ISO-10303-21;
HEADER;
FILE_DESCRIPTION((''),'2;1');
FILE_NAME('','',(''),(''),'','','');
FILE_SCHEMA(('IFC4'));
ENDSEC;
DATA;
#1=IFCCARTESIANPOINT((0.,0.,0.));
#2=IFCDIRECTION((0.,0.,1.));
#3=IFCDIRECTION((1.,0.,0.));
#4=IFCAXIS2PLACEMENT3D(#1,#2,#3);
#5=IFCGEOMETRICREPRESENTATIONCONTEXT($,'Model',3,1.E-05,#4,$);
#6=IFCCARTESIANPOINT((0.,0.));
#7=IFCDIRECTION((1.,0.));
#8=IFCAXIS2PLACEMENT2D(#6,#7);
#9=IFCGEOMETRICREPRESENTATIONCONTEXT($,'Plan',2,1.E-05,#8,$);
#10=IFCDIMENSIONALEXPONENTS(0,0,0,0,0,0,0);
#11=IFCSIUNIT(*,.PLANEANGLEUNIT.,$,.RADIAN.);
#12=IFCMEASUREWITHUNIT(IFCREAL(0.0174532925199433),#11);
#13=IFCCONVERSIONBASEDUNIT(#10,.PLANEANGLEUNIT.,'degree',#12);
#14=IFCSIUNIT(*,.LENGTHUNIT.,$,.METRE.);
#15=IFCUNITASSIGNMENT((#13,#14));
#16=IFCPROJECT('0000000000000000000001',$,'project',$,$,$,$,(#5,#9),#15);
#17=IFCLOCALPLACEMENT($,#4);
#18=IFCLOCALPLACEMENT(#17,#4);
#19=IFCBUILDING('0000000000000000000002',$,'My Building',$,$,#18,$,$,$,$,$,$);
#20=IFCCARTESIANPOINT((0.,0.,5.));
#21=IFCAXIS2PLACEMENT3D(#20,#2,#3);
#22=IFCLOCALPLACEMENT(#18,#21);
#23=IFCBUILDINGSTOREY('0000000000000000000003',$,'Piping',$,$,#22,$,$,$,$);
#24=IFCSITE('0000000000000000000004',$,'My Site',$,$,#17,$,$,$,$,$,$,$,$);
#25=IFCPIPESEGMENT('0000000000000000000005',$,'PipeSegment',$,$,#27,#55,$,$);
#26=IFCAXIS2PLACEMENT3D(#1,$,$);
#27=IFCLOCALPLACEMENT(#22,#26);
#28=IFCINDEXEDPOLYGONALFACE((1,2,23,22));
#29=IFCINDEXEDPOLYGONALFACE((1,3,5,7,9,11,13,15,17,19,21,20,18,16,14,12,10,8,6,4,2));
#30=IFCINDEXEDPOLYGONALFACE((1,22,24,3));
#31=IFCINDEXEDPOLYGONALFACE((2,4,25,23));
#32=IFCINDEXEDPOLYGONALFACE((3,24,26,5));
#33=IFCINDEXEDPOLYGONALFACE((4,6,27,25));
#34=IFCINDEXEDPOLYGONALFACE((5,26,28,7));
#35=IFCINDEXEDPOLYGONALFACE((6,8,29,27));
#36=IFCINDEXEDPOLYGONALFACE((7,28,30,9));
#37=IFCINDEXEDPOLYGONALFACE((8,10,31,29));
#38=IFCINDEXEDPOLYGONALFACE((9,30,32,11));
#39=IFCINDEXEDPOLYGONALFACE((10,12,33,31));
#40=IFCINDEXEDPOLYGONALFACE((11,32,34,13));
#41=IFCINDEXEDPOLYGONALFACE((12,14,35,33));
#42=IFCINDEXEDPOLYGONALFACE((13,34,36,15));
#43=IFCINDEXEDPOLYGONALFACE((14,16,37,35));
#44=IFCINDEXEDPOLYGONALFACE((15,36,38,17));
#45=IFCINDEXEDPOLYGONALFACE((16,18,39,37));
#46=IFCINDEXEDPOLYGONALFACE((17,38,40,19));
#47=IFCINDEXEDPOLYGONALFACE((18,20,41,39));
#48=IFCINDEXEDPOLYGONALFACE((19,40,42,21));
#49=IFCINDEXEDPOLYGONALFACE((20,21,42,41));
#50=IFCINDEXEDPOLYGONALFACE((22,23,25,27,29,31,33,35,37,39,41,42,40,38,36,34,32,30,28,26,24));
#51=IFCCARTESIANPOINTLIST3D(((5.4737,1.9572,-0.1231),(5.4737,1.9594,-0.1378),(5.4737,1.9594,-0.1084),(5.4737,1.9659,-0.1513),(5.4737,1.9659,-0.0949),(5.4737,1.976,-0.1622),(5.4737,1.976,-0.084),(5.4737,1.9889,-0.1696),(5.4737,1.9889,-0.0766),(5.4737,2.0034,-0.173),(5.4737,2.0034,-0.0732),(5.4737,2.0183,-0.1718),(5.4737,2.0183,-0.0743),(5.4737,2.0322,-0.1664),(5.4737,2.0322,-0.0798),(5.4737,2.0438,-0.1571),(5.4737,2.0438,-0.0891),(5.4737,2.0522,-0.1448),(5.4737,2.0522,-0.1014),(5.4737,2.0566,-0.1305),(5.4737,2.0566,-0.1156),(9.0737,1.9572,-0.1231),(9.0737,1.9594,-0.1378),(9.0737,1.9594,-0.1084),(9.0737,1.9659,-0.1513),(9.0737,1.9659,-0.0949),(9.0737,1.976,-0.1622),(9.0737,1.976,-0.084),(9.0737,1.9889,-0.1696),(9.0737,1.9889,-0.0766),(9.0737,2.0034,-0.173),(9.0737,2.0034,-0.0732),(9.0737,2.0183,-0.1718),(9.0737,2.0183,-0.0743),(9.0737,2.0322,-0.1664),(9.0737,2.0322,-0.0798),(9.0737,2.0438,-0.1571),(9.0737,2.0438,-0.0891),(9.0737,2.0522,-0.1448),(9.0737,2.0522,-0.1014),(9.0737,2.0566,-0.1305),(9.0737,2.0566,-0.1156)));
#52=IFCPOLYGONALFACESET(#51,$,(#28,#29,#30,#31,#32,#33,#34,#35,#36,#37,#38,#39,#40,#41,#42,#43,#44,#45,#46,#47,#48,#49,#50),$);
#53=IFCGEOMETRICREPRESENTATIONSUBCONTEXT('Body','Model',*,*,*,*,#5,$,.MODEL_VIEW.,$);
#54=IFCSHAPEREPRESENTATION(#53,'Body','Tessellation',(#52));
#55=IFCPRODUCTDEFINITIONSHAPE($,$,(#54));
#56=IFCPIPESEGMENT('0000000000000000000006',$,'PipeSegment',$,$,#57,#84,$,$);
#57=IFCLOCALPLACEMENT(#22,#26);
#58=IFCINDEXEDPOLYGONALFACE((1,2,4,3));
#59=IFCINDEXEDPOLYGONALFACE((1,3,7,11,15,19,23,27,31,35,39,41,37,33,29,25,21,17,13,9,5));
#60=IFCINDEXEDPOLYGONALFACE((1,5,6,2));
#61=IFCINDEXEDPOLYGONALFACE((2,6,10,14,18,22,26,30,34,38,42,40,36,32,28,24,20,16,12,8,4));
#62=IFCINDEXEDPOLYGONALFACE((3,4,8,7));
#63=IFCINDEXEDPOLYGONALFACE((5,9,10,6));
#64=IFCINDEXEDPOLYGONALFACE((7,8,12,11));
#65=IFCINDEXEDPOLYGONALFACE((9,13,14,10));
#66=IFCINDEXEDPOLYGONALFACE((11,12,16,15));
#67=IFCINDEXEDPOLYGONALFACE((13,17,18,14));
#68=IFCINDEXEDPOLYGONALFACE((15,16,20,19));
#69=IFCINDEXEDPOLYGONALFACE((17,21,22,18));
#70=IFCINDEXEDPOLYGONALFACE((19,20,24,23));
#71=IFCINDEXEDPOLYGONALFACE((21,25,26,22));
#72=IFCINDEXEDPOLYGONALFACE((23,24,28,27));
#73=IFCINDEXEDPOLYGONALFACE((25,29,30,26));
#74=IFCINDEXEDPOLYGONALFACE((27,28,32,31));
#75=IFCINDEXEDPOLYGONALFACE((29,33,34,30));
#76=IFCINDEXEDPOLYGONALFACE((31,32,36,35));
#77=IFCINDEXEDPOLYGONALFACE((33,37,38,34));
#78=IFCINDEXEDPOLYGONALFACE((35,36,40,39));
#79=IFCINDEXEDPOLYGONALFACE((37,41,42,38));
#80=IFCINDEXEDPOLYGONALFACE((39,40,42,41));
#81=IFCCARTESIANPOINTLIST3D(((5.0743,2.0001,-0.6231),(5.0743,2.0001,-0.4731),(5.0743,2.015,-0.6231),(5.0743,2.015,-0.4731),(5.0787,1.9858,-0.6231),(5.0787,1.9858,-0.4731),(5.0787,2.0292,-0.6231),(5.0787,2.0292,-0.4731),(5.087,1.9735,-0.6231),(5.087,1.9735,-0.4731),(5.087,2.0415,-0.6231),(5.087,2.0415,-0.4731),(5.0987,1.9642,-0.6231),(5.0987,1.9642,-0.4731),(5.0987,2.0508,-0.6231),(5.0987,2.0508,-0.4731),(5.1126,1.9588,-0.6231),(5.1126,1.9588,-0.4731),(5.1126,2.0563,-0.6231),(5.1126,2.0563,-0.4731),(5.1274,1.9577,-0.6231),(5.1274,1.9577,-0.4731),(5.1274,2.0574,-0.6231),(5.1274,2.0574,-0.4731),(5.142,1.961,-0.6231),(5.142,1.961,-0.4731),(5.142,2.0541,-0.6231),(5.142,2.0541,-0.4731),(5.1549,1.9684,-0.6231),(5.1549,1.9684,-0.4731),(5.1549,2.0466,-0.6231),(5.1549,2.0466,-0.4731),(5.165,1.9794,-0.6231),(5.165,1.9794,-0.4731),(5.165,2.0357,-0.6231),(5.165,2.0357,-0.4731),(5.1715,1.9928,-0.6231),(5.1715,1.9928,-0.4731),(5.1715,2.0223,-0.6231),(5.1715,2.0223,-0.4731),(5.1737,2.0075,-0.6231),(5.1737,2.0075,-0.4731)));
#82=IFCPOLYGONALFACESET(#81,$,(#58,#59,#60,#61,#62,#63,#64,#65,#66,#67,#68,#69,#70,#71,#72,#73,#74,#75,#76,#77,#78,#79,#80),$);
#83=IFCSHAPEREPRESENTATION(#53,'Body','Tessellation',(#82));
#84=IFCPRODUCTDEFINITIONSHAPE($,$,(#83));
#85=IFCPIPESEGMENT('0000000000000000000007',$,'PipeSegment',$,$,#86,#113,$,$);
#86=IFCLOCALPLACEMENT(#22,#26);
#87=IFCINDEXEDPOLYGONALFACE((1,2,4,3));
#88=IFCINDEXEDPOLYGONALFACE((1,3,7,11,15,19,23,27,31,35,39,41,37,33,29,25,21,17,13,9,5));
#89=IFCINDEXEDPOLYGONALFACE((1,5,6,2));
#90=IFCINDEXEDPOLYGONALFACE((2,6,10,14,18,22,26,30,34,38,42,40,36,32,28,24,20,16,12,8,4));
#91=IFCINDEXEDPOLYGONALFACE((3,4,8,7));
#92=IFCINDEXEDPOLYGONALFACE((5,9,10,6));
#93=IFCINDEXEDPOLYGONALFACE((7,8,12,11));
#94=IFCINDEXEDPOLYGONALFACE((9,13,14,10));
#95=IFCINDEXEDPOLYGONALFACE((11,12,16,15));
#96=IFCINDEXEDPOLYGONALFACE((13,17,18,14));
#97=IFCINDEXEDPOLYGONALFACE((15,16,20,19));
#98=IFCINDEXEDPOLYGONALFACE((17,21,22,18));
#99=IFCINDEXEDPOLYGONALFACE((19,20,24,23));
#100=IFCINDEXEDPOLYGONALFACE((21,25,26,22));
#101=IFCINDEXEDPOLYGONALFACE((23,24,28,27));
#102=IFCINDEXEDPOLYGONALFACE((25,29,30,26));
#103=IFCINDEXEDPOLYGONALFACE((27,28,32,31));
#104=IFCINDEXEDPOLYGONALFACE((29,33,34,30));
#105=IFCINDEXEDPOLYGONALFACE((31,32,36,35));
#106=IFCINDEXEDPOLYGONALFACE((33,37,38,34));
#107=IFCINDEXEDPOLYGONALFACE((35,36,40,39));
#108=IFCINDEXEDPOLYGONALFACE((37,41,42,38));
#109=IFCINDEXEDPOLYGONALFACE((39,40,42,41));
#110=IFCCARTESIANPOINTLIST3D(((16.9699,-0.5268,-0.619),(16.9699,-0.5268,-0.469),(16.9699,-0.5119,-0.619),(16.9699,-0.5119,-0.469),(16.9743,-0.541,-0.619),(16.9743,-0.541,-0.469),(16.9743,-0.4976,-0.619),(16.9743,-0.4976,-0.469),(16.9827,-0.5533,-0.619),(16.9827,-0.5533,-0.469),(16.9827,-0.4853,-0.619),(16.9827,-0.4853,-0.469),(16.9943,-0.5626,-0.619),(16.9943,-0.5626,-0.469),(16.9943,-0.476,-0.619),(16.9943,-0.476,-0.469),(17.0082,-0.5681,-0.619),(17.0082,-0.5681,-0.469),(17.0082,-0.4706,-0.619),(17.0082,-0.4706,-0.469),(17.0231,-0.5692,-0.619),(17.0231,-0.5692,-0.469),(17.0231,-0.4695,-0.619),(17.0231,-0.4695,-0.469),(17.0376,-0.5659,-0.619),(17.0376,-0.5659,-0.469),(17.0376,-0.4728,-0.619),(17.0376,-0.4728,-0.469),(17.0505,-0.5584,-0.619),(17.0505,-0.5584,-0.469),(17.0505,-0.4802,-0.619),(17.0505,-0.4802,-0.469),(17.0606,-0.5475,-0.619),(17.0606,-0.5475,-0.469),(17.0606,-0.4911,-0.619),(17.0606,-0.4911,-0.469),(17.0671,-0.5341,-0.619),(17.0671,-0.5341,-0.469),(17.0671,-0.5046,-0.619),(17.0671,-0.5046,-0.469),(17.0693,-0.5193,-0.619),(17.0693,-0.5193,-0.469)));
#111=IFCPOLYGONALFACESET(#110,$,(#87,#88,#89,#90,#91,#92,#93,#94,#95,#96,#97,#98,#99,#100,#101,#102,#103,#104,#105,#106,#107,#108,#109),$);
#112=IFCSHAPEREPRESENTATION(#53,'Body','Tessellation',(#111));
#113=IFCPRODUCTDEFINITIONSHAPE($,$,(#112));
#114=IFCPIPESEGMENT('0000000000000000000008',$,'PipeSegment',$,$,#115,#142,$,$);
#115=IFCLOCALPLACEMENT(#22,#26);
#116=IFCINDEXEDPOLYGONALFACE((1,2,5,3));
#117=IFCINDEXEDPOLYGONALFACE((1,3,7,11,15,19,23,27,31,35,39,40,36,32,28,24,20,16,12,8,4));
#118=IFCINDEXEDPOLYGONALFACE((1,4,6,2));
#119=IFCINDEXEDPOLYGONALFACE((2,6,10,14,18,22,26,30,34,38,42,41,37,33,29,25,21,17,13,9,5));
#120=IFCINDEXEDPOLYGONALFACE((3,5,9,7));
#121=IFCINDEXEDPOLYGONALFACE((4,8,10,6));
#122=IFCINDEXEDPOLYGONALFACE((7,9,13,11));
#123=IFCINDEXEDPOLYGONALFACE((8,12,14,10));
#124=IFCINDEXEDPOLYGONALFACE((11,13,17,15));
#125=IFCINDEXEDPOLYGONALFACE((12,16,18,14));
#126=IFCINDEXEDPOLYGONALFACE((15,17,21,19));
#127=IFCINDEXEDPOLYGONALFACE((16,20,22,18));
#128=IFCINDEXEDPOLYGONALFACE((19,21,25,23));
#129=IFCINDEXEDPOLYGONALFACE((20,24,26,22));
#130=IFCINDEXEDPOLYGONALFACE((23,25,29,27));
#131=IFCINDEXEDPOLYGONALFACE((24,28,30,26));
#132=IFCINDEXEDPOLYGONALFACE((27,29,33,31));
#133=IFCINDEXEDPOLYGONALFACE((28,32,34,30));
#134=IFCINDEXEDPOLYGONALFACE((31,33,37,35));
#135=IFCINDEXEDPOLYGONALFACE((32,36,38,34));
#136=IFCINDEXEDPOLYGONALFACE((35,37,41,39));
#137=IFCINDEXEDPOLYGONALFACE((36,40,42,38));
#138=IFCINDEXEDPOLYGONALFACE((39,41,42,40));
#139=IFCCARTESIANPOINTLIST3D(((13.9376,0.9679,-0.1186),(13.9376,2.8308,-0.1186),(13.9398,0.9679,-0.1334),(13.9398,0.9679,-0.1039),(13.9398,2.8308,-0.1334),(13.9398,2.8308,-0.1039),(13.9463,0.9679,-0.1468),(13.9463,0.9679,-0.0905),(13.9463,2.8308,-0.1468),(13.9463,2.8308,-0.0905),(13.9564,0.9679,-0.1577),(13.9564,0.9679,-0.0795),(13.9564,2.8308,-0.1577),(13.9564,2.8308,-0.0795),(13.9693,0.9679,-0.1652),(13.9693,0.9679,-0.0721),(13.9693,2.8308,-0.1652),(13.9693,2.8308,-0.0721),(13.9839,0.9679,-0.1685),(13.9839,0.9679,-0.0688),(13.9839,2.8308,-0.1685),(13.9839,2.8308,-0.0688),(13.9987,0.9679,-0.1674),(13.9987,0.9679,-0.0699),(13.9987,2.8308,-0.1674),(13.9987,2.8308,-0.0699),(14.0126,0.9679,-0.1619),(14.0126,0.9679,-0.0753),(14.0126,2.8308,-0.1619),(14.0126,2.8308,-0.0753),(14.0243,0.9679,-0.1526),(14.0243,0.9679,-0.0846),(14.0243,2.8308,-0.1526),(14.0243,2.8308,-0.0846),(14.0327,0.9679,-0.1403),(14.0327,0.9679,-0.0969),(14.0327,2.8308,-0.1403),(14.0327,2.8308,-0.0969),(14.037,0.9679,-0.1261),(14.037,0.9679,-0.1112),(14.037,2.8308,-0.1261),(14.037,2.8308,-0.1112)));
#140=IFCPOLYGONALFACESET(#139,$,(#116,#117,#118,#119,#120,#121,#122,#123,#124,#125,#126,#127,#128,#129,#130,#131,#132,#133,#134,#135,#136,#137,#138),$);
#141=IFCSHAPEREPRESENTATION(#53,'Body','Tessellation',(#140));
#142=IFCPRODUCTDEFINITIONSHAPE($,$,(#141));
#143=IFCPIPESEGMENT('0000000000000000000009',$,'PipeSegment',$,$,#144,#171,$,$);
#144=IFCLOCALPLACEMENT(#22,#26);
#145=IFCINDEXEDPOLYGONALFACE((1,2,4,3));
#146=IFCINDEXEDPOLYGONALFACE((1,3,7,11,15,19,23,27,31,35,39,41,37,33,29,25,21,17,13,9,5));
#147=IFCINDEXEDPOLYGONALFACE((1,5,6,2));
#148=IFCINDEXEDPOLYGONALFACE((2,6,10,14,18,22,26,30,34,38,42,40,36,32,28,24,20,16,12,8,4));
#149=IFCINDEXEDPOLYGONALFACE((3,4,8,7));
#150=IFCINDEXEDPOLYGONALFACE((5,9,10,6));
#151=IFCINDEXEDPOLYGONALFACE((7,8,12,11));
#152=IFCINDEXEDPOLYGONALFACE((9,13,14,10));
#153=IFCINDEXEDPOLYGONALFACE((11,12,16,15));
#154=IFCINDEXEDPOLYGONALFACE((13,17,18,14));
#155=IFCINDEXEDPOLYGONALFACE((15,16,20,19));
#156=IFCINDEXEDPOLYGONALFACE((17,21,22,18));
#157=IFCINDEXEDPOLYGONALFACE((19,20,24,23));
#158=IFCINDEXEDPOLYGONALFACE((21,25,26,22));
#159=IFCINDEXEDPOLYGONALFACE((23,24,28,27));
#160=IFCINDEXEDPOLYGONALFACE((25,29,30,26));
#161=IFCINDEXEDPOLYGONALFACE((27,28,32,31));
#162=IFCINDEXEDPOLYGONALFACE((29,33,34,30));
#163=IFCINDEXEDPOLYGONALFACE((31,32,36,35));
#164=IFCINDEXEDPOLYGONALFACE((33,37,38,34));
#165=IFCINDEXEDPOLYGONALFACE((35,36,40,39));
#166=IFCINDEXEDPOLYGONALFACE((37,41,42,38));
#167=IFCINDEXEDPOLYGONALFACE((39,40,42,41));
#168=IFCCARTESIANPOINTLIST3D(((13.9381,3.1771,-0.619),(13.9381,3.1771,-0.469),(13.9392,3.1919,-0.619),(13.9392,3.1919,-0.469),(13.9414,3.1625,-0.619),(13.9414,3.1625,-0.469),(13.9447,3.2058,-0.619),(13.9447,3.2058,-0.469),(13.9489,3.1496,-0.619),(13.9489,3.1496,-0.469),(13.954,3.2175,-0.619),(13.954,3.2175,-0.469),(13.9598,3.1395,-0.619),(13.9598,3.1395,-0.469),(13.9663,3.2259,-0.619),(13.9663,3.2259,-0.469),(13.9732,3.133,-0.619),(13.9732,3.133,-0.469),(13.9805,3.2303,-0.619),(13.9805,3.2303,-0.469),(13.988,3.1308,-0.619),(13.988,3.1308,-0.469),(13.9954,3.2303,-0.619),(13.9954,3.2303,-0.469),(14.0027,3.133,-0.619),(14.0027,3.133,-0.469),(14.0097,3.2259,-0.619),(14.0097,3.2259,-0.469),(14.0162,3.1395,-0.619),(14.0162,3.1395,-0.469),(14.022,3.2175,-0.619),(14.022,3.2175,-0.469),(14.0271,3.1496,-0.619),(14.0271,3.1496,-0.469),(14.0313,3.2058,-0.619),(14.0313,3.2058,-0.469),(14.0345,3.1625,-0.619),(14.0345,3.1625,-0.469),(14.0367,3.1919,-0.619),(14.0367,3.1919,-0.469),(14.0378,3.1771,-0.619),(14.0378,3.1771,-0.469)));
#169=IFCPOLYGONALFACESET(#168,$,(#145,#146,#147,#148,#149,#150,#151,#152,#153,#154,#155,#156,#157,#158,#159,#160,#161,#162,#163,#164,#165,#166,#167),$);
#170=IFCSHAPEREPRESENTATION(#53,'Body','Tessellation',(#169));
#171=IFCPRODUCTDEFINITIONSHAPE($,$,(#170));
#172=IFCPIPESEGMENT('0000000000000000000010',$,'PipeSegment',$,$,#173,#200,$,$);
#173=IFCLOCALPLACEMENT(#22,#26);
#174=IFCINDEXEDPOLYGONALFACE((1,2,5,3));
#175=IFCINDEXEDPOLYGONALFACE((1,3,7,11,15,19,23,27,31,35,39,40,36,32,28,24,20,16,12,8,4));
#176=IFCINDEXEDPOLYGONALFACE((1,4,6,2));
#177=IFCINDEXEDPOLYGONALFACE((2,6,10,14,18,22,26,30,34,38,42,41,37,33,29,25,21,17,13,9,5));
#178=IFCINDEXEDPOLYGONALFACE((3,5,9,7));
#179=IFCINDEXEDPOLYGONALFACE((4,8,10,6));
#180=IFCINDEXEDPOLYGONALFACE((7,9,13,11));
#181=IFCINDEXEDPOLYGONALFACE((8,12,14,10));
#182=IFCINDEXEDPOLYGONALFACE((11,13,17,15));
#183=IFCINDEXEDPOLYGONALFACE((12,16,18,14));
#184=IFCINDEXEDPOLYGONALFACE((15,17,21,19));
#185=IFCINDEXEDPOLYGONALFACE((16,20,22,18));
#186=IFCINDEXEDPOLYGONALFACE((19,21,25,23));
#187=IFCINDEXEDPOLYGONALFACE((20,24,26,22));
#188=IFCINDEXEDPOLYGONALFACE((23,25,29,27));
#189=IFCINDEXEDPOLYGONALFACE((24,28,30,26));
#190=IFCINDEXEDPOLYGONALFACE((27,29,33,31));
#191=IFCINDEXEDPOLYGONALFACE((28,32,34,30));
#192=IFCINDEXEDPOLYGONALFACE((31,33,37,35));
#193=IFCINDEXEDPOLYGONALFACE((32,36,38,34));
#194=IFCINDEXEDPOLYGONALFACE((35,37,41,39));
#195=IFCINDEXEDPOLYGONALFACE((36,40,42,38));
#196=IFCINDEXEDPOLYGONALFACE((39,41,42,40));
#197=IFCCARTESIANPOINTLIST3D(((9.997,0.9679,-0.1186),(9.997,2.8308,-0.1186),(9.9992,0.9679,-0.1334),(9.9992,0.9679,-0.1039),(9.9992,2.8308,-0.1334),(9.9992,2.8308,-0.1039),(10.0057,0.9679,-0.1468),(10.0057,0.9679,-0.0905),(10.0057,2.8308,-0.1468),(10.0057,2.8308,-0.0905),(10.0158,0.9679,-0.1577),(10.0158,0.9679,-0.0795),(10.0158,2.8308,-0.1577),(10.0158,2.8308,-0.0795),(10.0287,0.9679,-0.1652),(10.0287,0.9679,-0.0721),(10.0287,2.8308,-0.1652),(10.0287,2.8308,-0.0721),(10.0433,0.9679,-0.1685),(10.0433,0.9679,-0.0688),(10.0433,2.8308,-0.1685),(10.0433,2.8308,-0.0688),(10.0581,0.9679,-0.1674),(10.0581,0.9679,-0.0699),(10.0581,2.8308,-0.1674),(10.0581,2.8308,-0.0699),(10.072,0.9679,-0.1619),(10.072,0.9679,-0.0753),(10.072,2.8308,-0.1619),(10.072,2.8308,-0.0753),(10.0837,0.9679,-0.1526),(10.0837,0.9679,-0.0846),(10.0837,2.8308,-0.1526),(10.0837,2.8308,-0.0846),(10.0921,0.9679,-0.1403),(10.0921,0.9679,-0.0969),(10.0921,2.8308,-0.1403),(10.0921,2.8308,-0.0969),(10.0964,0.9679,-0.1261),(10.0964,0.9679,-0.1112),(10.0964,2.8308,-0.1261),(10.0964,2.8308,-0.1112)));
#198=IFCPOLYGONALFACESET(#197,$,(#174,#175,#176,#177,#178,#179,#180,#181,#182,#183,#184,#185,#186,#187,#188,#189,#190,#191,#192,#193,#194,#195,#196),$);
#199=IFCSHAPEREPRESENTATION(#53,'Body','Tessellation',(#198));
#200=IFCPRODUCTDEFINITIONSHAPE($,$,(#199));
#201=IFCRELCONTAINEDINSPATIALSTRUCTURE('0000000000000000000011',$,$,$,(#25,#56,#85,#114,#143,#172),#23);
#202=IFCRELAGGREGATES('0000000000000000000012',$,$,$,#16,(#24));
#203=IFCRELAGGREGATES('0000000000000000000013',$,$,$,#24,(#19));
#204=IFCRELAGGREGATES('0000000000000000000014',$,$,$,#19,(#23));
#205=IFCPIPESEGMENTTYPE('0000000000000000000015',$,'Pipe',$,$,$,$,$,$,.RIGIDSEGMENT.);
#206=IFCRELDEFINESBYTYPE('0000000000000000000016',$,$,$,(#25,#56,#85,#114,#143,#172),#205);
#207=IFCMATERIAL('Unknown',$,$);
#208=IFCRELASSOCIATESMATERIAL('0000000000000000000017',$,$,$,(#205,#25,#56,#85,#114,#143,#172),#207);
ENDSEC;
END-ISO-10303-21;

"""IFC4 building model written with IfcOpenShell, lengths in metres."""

from ifc_helpers import new_model, entity, si_unit, converted_unit, frame, origin_with_axes, origin_2d_with_axis, place, context, subcontext, project, spatial, circle, extrude, material, material_profile, profile_set, profile_usage, type_object, element, save


model = new_model("IFC4")

# Units and contexts
model_context = context("Model", 3, precision=1e-05, world=origin_with_axes())
plan_context = context("Plan", 2, precision=1e-05, world=origin_2d_with_axis())
body_context = subcontext(model_context, "Body", "Model", "MODEL_VIEW")
ifc_project = project(units=[converted_unit("PLANEANGLEUNIT", "degree", entity("IfcReal", 0.0174532925199433), si_unit("PLANEANGLEUNIT", "RADIAN"), dimensions=[0, 0, 0, 0, 0, 0, 0]), si_unit("LENGTHUNIT", "METRE")], contexts=[model_context, plan_context])

# Site, building, storey
site_placement = place(None, origin_with_axes())
site = spatial("IfcSite", under=ifc_project, at=site_placement, Name="My Site")
building_placement = place(site_placement, origin_with_axes())
building = spatial("IfcBuilding", under=site, at=building_placement, Name="My Building")
storey_placement = place(building_placement, frame((0.0, 0.0, 5.0), z_axis=(0.0, 0.0, 1.0), x_axis=(1.0, 0.0, 0.0)))
storey = spatial("IfcBuildingStorey", under=building, at=storey_placement, Name="Piping")

# Pipe segments
ifc_material = material(Name="Unknown")
ifc_material_profile_1 = material_profile(ifc_material, circle(Radius=0.05))
ifc_profile_set_1 = profile_set([ifc_material_profile_1])
pipe_segment_type = type_object("IfcPipeSegmentType", Name="Pipe", PredefinedType="RIGIDSEGMENT", material=ifc_profile_set_1)
ifc_profile_usage_1 = profile_usage(ifc_profile_set_1, cardinal=5)
pipe_segment_1_placement = place(storey_placement, frame((9.0737, 2.0072, -0.1231), z_axis=(-1.0, 0.0, 0.0), x_axis=(0.0, -1.0, 0.0)))
element("IfcPipeSegment", 1, at=pipe_segment_1_placement, inside=storey, type_object=pipe_segment_type, material=ifc_profile_usage_1, Name="PipeSegment", context=body_context, shape_type="SweptSolid", body=[
    extrude(circle(Radius=0.05), origin_with_axes(), (0.0, 0.0, 1.0), 3.6),
])
ifc_profile_usage_2 = profile_usage(ifc_profile_set_1, cardinal=5)
pipe_segment_2_placement = place(storey_placement, frame((5.1237, 2.0075, -0.4731), z_axis=(0.0, 0.0, -1.0), x_axis=(1.0, 0.0, 0.0)))
element("IfcPipeSegment", 2, at=pipe_segment_2_placement, inside=storey, type_object=pipe_segment_type, material=ifc_profile_usage_2, Name="PipeSegment", context=body_context, shape_type="SweptSolid", body=[
    extrude(circle(Radius=0.05), origin_with_axes(), (0.0, 0.0, 1.0), 0.15),
])
ifc_profile_usage_3 = profile_usage(ifc_profile_set_1, cardinal=5)
pipe_segment_3_placement = place(storey_placement, frame((17.0193, -0.5193, -0.469), z_axis=(0.0, 0.0, -1.0), x_axis=(1.0, -0.000053, 0.0)))
element("IfcPipeSegment", 3, at=pipe_segment_3_placement, inside=storey, type_object=pipe_segment_type, material=ifc_profile_usage_3, Name="PipeSegment", context=body_context, shape_type="SweptSolid", body=[
    extrude(circle(Radius=0.05), origin_with_axes(), (0.0, 0.0, 1.0), 0.15),
])
ifc_profile_usage_4 = profile_usage(ifc_profile_set_1, cardinal=5)
pipe_segment_4_placement = place(storey_placement, frame((13.9876, 0.9679, -0.1186), z_axis=(0.0, 1.0, 0.0), x_axis=(-1.0, 0.0, 0.0)))
element("IfcPipeSegment", 4, at=pipe_segment_4_placement, inside=storey, type_object=pipe_segment_type, material=ifc_profile_usage_4, Name="PipeSegment", context=body_context, shape_type="SweptSolid", body=[
    extrude(circle(Radius=0.05), origin_with_axes(), (0.0, 0.0, 1.0), 1.8629),
])
ifc_profile_usage_5 = profile_usage(ifc_profile_set_1, cardinal=5)
pipe_segment_5_placement = place(storey_placement, frame((13.988, 3.1808, -0.469), z_axis=(0.0, 0.0, -1.0), x_axis=(-0.000053, -1.0, 0.0)))
element("IfcPipeSegment", 5, at=pipe_segment_5_placement, inside=storey, type_object=pipe_segment_type, material=ifc_profile_usage_5, Name="PipeSegment", context=body_context, shape_type="SweptSolid", body=[
    extrude(circle(Radius=0.05), origin_with_axes(), (0.0, 0.0, 1.0), 0.15),
])
ifc_profile_usage_6 = profile_usage(ifc_profile_set_1, cardinal=5)
pipe_segment_6_placement = place(storey_placement, frame((10.047, 0.9679, -0.1186), z_axis=(0.0, 1.0, 0.0), x_axis=(-1.0, 0.0, 0.0)))
element("IfcPipeSegment", 6, at=pipe_segment_6_placement, inside=storey, type_object=pipe_segment_type, material=ifc_profile_usage_6, Name="PipeSegment", context=body_context, shape_type="SweptSolid", body=[
    extrude(circle(Radius=0.05), origin_with_axes(), (0.0, 0.0, 1.0), 1.8629),
])

save(model, "model.ifc")
